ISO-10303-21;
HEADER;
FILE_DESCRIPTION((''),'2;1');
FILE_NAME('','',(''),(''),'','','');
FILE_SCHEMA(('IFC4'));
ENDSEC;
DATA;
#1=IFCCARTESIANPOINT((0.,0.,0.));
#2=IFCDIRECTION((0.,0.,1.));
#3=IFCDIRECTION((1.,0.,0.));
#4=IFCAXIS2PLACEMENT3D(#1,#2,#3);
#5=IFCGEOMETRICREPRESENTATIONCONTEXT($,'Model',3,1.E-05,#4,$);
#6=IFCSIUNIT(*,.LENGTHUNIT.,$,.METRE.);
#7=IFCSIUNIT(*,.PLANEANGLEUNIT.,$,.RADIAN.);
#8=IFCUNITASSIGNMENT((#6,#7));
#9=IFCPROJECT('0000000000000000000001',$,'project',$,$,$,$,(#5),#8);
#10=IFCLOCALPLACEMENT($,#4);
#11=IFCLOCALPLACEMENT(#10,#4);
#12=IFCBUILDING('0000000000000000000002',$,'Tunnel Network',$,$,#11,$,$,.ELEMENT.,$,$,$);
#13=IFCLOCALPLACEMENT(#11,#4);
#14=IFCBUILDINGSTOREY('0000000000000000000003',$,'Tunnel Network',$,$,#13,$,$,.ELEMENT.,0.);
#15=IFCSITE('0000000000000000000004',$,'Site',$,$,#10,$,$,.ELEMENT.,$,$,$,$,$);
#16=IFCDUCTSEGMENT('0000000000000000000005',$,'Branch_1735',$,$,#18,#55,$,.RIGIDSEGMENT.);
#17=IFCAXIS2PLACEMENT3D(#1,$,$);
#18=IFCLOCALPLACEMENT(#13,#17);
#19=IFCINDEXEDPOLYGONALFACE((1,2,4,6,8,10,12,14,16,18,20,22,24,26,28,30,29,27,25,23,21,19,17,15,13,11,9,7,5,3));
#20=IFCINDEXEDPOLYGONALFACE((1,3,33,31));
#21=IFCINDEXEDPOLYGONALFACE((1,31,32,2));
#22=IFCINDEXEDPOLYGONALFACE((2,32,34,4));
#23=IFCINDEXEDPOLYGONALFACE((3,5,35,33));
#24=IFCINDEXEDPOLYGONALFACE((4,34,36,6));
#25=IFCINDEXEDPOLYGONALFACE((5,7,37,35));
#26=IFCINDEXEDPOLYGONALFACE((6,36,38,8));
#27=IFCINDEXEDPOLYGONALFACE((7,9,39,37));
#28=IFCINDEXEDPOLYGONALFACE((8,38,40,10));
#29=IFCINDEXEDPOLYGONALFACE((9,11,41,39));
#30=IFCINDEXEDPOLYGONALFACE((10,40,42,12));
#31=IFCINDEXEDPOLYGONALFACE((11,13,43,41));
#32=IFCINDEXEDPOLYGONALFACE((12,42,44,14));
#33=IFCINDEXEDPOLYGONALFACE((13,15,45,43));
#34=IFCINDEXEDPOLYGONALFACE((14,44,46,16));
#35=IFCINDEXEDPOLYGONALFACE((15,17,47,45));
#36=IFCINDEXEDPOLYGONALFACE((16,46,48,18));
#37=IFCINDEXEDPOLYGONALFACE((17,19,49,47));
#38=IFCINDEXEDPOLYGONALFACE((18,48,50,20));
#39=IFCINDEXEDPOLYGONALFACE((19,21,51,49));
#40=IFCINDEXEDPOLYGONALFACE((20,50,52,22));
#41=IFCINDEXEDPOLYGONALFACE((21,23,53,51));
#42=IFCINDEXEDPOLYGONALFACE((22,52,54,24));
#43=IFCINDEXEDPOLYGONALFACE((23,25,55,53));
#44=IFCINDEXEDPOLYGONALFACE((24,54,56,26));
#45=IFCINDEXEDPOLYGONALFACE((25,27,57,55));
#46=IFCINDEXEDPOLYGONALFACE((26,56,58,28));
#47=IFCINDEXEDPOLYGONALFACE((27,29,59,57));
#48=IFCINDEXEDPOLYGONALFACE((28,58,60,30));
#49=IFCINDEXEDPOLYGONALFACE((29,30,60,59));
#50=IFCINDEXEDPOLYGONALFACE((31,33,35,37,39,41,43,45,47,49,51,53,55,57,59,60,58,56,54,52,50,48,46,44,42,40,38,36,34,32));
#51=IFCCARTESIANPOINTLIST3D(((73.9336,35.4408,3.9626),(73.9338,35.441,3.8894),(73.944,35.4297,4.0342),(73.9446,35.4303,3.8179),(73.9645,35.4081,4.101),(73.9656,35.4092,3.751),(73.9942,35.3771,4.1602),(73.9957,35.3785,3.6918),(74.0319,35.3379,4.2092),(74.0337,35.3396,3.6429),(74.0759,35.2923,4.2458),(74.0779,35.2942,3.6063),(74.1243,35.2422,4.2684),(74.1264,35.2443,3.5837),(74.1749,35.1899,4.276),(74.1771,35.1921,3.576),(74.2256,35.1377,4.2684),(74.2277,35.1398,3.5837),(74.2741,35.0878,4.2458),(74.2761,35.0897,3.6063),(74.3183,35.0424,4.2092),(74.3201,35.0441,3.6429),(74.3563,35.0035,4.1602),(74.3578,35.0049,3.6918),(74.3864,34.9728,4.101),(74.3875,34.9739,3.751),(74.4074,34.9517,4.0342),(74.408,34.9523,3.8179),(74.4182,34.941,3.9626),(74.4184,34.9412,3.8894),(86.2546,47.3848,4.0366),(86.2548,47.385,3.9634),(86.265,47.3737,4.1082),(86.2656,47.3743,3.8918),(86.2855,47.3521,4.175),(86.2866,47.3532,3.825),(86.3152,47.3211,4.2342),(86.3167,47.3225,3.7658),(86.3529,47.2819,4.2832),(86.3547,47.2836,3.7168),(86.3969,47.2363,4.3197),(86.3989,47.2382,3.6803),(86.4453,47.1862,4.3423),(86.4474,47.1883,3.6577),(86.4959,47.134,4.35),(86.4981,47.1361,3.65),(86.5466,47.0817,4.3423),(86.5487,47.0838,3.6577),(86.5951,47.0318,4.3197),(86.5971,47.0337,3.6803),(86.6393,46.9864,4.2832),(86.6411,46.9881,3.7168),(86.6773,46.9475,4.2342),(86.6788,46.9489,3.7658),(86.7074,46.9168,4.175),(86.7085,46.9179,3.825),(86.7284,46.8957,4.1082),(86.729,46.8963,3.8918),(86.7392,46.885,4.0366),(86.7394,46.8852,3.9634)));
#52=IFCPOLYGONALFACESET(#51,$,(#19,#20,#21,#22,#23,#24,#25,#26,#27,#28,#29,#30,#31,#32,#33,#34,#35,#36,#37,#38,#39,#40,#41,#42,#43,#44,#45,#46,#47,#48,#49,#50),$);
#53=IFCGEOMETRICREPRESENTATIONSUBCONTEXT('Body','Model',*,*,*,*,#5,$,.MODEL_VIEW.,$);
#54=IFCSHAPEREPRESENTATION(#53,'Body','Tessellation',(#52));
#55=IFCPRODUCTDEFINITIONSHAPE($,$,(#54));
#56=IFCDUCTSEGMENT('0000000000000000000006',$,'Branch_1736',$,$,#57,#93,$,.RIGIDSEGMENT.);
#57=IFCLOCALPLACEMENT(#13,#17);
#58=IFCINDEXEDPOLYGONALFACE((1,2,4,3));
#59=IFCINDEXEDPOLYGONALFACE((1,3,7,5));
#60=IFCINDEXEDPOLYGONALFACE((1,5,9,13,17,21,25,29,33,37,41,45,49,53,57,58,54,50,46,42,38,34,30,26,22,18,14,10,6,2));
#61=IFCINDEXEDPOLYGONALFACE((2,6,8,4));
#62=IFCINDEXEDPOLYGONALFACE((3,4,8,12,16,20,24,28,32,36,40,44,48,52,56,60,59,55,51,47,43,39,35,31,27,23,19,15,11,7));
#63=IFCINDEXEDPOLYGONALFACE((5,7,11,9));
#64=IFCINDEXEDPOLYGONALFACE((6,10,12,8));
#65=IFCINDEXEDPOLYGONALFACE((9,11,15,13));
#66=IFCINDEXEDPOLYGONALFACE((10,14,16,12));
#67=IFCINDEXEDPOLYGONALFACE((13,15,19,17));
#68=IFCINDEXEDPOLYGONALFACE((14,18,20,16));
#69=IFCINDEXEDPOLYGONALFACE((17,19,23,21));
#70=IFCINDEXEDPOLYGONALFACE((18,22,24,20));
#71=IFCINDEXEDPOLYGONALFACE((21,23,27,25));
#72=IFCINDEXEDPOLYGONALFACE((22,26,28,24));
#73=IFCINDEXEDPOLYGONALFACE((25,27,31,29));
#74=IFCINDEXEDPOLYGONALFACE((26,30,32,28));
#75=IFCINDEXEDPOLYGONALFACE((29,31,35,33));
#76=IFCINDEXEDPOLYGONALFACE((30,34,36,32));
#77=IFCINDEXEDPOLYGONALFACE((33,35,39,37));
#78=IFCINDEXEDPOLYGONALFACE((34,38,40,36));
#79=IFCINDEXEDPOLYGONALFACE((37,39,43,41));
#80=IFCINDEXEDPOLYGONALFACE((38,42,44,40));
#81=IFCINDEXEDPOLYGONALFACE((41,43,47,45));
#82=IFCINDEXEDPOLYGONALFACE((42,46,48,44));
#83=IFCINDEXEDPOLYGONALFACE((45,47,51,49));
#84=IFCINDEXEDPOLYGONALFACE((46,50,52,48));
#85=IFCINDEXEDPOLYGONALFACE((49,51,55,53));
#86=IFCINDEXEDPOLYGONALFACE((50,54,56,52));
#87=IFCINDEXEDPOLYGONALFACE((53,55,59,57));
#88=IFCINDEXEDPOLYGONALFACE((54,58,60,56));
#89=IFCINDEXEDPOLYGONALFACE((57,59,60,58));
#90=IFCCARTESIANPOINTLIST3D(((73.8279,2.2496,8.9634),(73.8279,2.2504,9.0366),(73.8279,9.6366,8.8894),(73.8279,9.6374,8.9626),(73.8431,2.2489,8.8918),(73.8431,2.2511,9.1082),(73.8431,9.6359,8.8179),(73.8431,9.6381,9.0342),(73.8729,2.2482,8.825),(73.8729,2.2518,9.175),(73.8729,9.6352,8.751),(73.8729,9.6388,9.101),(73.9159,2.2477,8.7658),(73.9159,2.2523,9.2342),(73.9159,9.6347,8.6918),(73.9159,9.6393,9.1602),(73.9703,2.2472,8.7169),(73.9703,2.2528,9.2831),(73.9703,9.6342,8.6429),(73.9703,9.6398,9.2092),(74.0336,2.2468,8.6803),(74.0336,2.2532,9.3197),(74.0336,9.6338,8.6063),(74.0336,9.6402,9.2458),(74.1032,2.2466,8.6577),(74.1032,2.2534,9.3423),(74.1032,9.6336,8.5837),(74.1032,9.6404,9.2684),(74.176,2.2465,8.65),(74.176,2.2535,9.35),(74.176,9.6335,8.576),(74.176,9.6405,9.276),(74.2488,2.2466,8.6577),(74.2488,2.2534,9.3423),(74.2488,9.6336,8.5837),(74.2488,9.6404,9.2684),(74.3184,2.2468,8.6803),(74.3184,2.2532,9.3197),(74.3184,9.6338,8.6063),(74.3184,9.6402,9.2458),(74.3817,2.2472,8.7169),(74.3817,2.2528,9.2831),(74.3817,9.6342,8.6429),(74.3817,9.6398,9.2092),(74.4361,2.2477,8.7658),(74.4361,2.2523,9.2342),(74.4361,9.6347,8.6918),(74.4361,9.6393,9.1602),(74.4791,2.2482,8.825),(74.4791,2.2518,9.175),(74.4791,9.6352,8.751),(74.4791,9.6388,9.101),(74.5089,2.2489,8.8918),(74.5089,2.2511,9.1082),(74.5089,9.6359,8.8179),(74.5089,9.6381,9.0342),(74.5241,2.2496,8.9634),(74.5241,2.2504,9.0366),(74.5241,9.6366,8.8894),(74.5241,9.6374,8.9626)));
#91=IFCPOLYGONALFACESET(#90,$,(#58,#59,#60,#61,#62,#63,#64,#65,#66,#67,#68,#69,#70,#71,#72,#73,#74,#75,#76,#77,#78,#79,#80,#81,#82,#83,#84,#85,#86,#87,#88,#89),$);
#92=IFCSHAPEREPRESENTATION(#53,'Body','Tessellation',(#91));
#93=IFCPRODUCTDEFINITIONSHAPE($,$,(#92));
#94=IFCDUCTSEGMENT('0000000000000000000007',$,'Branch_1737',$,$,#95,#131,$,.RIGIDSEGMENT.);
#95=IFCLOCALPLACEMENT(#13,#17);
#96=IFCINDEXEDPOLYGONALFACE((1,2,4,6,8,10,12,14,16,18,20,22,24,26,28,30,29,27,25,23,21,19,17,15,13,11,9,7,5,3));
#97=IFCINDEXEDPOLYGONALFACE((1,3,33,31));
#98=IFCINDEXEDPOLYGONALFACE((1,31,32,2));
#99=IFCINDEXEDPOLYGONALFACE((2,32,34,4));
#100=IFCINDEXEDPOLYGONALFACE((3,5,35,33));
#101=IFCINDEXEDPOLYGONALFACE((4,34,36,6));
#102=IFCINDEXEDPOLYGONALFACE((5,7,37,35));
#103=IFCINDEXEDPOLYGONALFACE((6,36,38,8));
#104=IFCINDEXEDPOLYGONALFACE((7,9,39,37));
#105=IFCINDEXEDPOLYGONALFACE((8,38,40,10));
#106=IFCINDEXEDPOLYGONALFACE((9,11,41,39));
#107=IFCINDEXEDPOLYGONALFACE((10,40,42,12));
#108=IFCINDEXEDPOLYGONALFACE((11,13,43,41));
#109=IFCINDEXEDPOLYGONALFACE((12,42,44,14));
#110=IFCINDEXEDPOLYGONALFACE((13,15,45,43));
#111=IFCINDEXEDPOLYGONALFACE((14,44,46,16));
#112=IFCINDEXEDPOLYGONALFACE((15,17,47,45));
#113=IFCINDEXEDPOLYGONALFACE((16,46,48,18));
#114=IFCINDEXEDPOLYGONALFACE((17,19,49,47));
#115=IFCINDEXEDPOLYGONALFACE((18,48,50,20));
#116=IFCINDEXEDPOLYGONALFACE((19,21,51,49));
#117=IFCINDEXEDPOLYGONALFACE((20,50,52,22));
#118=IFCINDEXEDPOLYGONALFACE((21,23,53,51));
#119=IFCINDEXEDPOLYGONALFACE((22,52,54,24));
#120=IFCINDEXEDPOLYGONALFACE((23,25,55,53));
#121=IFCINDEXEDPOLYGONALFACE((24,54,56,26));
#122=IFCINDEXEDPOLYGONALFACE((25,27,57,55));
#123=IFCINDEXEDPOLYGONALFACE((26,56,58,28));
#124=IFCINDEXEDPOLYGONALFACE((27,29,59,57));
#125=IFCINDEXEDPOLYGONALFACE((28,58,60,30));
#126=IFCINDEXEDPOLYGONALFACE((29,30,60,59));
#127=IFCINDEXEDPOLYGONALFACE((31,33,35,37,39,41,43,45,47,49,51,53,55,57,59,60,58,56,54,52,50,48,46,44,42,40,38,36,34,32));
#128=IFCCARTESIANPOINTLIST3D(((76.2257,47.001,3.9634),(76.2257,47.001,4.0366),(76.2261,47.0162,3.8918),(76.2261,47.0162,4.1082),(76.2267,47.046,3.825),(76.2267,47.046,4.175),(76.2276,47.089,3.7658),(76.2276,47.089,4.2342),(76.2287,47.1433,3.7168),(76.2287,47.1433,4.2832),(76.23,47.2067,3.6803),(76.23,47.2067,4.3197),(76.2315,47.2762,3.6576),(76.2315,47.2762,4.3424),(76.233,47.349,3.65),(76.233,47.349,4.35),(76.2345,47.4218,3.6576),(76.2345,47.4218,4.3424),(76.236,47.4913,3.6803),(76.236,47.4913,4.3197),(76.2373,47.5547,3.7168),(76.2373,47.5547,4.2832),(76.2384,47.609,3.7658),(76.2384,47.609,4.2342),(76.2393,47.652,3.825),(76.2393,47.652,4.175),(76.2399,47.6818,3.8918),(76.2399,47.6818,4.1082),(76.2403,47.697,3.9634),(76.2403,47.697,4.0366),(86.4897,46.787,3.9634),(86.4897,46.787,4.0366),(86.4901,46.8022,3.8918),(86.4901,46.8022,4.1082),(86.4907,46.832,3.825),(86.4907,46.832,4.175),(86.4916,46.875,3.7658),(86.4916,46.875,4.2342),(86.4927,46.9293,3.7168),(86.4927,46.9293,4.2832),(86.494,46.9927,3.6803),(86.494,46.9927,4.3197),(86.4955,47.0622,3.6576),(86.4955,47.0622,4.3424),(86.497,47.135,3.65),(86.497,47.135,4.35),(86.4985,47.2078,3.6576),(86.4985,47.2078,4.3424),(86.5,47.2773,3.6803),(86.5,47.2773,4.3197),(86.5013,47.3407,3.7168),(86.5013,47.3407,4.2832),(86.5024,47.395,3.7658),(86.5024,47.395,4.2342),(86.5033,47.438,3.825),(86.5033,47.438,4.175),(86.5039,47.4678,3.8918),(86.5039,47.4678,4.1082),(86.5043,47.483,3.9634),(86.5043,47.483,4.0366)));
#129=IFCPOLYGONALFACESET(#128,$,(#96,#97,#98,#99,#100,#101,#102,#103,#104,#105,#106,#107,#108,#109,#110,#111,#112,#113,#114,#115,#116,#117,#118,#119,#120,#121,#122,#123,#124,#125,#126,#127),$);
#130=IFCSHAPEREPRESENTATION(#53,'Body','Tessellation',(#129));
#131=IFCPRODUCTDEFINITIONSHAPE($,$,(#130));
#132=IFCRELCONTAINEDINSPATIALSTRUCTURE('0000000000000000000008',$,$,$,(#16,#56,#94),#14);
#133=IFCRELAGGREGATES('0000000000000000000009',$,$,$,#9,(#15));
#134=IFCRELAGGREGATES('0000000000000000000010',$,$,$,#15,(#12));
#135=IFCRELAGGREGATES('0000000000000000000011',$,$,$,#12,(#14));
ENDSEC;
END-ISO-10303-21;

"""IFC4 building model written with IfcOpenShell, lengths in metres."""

from ifc_helpers import new_model, si_unit, frame, origin_with_axes, origin_2d_with_axis, place, context, subcontext, project, spatial, circle, extrude, element, save


model = new_model("IFC4")

# Units and contexts
model_context = context("Model", 3, precision=1e-05, world=origin_with_axes())
body_context = subcontext(model_context, "Body", "Model", "MODEL_VIEW")
ifc_project = project(units=[si_unit("LENGTHUNIT", "METRE"), si_unit("PLANEANGLEUNIT", "RADIAN")], contexts=[model_context])

# Site, building, storey
site_placement = place(None, origin_with_axes())
site = spatial("IfcSite", under=ifc_project, at=site_placement, Name="Site", CompositionType="ELEMENT")
building_placement = place(site_placement, origin_with_axes())
building = spatial("IfcBuilding", under=site, at=building_placement, Name="Tunnel Network", CompositionType="ELEMENT")
storey_placement = place(building_placement, origin_with_axes())
storey = spatial("IfcBuildingStorey", under=building, at=storey_placement, Name="Tunnel Network", CompositionType="ELEMENT", Elevation=0.0)

# Duct segments
duct_segment_1_placement = place(storey_placement, frame((74.176, 35.191, 3.926), z_axis=(0.718, 0.69603, 0.004311), x_axis=(-0.003095, -0.003, 0.999991)))
element("IfcDuctSegment", 1, at=duct_segment_1_placement, inside=storey, Name="Branch_1735", PredefinedType="RIGIDSEGMENT", context=body_context, shape_type="SweptSolid", body=[
    extrude(circle(Radius=0.35, at=origin_2d_with_axis()), origin_with_axes(), (0.0, 0.0, 1.0), 17.1602),
])
duct_segment_2_placement = place(storey_placement, frame((74.176, 2.25, 9.0), z_axis=(0.0, 0.99995, -0.010014), x_axis=(0.0, 0.010014, 0.99995)))
element("IfcDuctSegment", 2, at=duct_segment_2_placement, inside=storey, Name="Branch_1736", PredefinedType="RIGIDSEGMENT", context=body_context, shape_type="SweptSolid", body=[
    extrude(circle(Radius=0.35, at=origin_2d_with_axis()), origin_with_axes(), (0.0, 0.0, 1.0), 7.3874),
])
duct_segment_3_placement = place(storey_placement, frame((86.497, 47.135, 4.0), z_axis=(-0.999783, 0.020845, 0.0), x_axis=(0.0, 0.0, 1.0)))
element("IfcDuctSegment", 3, at=duct_segment_3_placement, inside=storey, Name="Branch_1737", PredefinedType="RIGIDSEGMENT", context=body_context, shape_type="SweptSolid", body=[
    extrude(circle(Radius=0.35, at=origin_2d_with_axis()), origin_with_axes(), (0.0, 0.0, 1.0), 10.2662),
])

save(model, "model.ifc")
